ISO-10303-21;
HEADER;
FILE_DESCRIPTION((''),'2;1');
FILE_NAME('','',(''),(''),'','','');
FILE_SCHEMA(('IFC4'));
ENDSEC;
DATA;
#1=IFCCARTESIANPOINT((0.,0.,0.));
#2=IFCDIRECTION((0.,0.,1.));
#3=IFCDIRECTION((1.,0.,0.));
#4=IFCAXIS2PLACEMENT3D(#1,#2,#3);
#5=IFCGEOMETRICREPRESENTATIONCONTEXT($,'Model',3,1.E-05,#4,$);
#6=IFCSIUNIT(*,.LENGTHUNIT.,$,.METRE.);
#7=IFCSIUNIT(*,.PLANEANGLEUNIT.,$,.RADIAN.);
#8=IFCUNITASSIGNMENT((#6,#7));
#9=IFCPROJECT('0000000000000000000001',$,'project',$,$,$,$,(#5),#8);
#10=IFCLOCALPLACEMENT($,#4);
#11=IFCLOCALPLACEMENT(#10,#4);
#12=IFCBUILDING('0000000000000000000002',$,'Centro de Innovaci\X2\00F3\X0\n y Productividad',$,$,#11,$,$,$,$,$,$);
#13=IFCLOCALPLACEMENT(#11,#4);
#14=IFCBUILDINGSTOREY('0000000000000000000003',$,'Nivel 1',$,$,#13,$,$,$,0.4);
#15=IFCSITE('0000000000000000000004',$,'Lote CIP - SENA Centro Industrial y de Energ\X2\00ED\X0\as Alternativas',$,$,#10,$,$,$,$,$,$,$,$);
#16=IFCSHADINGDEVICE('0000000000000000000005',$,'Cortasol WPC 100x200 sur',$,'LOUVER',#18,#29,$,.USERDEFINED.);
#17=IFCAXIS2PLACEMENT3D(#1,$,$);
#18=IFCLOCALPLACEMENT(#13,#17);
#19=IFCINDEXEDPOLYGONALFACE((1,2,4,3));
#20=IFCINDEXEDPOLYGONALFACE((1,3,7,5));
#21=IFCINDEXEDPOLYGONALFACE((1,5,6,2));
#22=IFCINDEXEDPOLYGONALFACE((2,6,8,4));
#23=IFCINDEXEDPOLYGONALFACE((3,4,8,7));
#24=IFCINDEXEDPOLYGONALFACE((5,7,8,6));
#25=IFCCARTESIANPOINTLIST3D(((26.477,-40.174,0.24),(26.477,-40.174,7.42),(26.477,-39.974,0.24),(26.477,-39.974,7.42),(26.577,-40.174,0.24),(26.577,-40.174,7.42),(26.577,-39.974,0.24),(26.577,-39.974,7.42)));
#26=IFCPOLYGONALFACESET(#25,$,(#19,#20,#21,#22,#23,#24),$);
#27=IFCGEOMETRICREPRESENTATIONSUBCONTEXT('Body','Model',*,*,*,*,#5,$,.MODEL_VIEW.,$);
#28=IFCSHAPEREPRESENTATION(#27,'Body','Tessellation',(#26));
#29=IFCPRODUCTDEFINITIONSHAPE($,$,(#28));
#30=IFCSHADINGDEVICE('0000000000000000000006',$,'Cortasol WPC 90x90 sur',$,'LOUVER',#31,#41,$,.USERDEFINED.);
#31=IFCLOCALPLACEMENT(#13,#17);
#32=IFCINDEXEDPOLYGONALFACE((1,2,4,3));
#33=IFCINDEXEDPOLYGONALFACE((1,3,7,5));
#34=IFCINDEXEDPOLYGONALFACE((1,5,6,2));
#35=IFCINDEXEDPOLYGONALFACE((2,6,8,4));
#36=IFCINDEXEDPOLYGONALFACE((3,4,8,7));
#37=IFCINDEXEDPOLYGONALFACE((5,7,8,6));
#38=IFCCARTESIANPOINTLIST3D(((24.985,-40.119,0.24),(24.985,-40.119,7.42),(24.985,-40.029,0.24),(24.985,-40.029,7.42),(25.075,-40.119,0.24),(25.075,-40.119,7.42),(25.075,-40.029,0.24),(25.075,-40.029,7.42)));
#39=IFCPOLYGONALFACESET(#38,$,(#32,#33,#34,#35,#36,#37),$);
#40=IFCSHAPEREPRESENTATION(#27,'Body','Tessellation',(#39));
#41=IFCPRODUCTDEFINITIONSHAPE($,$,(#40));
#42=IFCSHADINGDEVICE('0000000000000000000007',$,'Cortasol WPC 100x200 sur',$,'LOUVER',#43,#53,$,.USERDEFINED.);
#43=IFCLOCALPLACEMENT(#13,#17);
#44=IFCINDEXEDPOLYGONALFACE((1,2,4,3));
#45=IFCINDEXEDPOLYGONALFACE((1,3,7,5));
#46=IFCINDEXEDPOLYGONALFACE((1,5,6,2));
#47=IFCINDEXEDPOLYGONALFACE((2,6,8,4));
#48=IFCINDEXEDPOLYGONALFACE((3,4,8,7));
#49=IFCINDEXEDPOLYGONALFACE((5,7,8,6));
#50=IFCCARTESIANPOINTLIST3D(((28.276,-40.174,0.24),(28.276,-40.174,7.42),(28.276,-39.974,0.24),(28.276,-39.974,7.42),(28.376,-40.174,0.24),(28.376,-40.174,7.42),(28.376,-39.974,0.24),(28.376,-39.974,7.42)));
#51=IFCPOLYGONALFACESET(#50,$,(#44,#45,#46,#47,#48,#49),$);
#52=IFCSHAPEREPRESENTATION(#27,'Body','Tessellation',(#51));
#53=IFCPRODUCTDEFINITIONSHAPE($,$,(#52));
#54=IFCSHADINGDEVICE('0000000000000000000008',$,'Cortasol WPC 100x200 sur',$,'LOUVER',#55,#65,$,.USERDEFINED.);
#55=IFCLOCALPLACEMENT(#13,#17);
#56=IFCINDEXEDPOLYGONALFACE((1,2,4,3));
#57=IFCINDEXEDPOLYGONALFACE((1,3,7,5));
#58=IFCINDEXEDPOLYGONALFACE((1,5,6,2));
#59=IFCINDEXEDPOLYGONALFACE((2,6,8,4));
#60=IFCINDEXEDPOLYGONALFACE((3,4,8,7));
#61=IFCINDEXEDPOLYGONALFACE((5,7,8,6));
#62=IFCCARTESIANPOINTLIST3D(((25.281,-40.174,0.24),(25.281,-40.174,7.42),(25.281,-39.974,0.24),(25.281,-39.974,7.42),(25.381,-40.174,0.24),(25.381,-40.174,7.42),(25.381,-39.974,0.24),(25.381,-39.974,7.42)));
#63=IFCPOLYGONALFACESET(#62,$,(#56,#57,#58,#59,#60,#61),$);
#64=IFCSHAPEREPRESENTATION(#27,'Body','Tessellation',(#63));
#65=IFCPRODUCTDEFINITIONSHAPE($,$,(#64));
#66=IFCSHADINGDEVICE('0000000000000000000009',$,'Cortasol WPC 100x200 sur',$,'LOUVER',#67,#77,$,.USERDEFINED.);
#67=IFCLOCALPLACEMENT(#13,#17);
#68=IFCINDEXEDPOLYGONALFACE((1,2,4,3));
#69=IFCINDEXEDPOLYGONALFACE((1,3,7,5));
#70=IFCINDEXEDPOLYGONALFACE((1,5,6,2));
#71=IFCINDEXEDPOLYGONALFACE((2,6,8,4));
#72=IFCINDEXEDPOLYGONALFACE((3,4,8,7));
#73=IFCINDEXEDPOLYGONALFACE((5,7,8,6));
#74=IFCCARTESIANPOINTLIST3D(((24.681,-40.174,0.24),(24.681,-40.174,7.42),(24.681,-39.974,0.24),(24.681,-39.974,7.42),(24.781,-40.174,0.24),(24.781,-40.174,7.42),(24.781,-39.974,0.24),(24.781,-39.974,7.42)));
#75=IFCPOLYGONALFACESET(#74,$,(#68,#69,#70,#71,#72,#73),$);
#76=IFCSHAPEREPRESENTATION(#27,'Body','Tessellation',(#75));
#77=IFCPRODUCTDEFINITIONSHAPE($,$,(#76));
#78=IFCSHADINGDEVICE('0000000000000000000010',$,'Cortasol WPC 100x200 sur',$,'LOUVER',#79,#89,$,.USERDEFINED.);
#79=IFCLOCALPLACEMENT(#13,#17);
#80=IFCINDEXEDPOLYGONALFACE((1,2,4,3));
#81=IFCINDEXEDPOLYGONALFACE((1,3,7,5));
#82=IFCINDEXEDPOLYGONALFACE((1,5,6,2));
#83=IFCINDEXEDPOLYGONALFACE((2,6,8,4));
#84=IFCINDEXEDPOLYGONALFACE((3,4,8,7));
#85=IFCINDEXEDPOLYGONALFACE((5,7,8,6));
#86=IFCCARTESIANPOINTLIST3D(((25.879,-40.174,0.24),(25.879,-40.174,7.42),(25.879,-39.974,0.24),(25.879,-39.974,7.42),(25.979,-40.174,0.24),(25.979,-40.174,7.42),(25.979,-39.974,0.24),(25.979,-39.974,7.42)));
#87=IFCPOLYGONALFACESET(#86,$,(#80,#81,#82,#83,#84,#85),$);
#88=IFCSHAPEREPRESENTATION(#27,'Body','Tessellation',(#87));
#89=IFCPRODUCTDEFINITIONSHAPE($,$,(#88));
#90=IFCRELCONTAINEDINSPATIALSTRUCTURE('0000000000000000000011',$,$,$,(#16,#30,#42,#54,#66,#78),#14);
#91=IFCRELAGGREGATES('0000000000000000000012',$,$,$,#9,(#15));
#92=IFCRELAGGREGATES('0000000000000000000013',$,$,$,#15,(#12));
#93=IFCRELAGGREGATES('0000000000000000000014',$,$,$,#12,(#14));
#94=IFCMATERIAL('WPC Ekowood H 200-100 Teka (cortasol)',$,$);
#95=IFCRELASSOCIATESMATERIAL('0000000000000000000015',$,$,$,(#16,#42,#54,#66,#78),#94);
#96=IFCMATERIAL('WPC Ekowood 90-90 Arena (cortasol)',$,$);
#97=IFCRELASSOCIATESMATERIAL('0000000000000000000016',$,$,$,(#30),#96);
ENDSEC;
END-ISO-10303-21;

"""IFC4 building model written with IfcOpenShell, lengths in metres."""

from ifc_helpers import new_model, si_unit, frame, origin_with_axes, place, context, subcontext, project, spatial, polyline, outline, extrude, material, element, save


model = new_model("IFC4")

# Units and contexts
model_context = context("Model", 3, precision=1e-05, world=origin_with_axes())
body_context = subcontext(model_context, "Body", "Model", "MODEL_VIEW")
ifc_project = project(units=[si_unit("LENGTHUNIT", "METRE"), si_unit("PLANEANGLEUNIT", "RADIAN")], contexts=[model_context])

# Site, building, storey
site_placement = place(None, origin_with_axes())
site = spatial("IfcSite", under=ifc_project, at=site_placement, Name="Lote CIP - SENA Centro Industrial y de Energías Alternativas")
building_placement = place(site_placement, origin_with_axes())
building = spatial("IfcBuilding", under=site, at=building_placement, Name="Centro de Innovación y Productividad")
storey_placement = place(building_placement, origin_with_axes())
storey = spatial("IfcBuildingStorey", under=building, at=storey_placement, Name="Nivel 1", Elevation=0.4)

# Shading devices
ifc_material_1 = material(Name="WPC Ekowood 90-90 Arena (cortasol)")
ifc_material_2 = material(Name="WPC Ekowood H 200-100 Teka (cortasol)")
shading_device_1_placement = place(storey_placement, origin_with_axes())
element("IfcShadingDevice", 1, at=shading_device_1_placement, inside=storey, material=ifc_material_2, Name="Cortasol WPC 100x200 sur", ObjectType="LOUVER", PredefinedType="USERDEFINED", context=body_context, shape_type="SweptSolid", body=[
    extrude(outline(polyline([(26.477, -40.174), (26.477, -39.974), (26.577, -39.974), (26.577, -40.174), (26.477, -40.174)])), frame((0.0, 0.0, 0.24)), (0.0, 0.0, 1.0), 7.18),
])
shading_device_2_placement = place(storey_placement, origin_with_axes())
element("IfcShadingDevice", 2, at=shading_device_2_placement, inside=storey, material=ifc_material_1, Name="Cortasol WPC 90x90 sur", ObjectType="LOUVER", PredefinedType="USERDEFINED", context=body_context, shape_type="SweptSolid", body=[
    extrude(outline(polyline([(24.985, -40.119), (24.985, -40.029), (25.075, -40.029), (25.075, -40.119), (24.985, -40.119)])), frame((0.0, 0.0, 0.24)), (0.0, 0.0, 1.0), 7.18),
])
shading_device_3_placement = place(storey_placement, origin_with_axes())
element("IfcShadingDevice", 3, at=shading_device_3_placement, inside=storey, material=ifc_material_2, Name="Cortasol WPC 100x200 sur", ObjectType="LOUVER", PredefinedType="USERDEFINED", context=body_context, shape_type="SweptSolid", body=[
    extrude(outline(polyline([(28.276, -40.174), (28.276, -39.974), (28.376, -39.974), (28.376, -40.174), (28.276, -40.174)])), frame((0.0, 0.0, 0.24)), (0.0, 0.0, 1.0), 7.18),
])
shading_device_4_placement = place(storey_placement, origin_with_axes())
element("IfcShadingDevice", 4, at=shading_device_4_placement, inside=storey, material=ifc_material_2, Name="Cortasol WPC 100x200 sur", ObjectType="LOUVER", PredefinedType="USERDEFINED", context=body_context, shape_type="SweptSolid", body=[
    extrude(outline(polyline([(25.281, -40.174), (25.281, -39.974), (25.381, -39.974), (25.381, -40.174), (25.281, -40.174)])), frame((0.0, 0.0, 0.24)), (0.0, 0.0, 1.0), 7.18),
])
shading_device_5_placement = place(storey_placement, origin_with_axes())
element("IfcShadingDevice", 5, at=shading_device_5_placement, inside=storey, material=ifc_material_2, Name="Cortasol WPC 100x200 sur", ObjectType="LOUVER", PredefinedType="USERDEFINED", context=body_context, shape_type="SweptSolid", body=[
    extrude(outline(polyline([(24.681, -40.174), (24.681, -39.974), (24.781, -39.974), (24.781, -40.174), (24.681, -40.174)])), frame((0.0, 0.0, 0.24)), (0.0, 0.0, 1.0), 7.18),
])
shading_device_6_placement = place(storey_placement, origin_with_axes())
element("IfcShadingDevice", 6, at=shading_device_6_placement, inside=storey, material=ifc_material_2, Name="Cortasol WPC 100x200 sur", ObjectType="LOUVER", PredefinedType="USERDEFINED", context=body_context, shape_type="SweptSolid", body=[
    extrude(outline(polyline([(25.879, -40.174), (25.879, -39.974), (25.979, -39.974), (25.979, -40.174), (25.879, -40.174)])), frame((0.0, 0.0, 0.24)), (0.0, 0.0, 1.0), 7.18),
])

save(model, "model.ifc")
